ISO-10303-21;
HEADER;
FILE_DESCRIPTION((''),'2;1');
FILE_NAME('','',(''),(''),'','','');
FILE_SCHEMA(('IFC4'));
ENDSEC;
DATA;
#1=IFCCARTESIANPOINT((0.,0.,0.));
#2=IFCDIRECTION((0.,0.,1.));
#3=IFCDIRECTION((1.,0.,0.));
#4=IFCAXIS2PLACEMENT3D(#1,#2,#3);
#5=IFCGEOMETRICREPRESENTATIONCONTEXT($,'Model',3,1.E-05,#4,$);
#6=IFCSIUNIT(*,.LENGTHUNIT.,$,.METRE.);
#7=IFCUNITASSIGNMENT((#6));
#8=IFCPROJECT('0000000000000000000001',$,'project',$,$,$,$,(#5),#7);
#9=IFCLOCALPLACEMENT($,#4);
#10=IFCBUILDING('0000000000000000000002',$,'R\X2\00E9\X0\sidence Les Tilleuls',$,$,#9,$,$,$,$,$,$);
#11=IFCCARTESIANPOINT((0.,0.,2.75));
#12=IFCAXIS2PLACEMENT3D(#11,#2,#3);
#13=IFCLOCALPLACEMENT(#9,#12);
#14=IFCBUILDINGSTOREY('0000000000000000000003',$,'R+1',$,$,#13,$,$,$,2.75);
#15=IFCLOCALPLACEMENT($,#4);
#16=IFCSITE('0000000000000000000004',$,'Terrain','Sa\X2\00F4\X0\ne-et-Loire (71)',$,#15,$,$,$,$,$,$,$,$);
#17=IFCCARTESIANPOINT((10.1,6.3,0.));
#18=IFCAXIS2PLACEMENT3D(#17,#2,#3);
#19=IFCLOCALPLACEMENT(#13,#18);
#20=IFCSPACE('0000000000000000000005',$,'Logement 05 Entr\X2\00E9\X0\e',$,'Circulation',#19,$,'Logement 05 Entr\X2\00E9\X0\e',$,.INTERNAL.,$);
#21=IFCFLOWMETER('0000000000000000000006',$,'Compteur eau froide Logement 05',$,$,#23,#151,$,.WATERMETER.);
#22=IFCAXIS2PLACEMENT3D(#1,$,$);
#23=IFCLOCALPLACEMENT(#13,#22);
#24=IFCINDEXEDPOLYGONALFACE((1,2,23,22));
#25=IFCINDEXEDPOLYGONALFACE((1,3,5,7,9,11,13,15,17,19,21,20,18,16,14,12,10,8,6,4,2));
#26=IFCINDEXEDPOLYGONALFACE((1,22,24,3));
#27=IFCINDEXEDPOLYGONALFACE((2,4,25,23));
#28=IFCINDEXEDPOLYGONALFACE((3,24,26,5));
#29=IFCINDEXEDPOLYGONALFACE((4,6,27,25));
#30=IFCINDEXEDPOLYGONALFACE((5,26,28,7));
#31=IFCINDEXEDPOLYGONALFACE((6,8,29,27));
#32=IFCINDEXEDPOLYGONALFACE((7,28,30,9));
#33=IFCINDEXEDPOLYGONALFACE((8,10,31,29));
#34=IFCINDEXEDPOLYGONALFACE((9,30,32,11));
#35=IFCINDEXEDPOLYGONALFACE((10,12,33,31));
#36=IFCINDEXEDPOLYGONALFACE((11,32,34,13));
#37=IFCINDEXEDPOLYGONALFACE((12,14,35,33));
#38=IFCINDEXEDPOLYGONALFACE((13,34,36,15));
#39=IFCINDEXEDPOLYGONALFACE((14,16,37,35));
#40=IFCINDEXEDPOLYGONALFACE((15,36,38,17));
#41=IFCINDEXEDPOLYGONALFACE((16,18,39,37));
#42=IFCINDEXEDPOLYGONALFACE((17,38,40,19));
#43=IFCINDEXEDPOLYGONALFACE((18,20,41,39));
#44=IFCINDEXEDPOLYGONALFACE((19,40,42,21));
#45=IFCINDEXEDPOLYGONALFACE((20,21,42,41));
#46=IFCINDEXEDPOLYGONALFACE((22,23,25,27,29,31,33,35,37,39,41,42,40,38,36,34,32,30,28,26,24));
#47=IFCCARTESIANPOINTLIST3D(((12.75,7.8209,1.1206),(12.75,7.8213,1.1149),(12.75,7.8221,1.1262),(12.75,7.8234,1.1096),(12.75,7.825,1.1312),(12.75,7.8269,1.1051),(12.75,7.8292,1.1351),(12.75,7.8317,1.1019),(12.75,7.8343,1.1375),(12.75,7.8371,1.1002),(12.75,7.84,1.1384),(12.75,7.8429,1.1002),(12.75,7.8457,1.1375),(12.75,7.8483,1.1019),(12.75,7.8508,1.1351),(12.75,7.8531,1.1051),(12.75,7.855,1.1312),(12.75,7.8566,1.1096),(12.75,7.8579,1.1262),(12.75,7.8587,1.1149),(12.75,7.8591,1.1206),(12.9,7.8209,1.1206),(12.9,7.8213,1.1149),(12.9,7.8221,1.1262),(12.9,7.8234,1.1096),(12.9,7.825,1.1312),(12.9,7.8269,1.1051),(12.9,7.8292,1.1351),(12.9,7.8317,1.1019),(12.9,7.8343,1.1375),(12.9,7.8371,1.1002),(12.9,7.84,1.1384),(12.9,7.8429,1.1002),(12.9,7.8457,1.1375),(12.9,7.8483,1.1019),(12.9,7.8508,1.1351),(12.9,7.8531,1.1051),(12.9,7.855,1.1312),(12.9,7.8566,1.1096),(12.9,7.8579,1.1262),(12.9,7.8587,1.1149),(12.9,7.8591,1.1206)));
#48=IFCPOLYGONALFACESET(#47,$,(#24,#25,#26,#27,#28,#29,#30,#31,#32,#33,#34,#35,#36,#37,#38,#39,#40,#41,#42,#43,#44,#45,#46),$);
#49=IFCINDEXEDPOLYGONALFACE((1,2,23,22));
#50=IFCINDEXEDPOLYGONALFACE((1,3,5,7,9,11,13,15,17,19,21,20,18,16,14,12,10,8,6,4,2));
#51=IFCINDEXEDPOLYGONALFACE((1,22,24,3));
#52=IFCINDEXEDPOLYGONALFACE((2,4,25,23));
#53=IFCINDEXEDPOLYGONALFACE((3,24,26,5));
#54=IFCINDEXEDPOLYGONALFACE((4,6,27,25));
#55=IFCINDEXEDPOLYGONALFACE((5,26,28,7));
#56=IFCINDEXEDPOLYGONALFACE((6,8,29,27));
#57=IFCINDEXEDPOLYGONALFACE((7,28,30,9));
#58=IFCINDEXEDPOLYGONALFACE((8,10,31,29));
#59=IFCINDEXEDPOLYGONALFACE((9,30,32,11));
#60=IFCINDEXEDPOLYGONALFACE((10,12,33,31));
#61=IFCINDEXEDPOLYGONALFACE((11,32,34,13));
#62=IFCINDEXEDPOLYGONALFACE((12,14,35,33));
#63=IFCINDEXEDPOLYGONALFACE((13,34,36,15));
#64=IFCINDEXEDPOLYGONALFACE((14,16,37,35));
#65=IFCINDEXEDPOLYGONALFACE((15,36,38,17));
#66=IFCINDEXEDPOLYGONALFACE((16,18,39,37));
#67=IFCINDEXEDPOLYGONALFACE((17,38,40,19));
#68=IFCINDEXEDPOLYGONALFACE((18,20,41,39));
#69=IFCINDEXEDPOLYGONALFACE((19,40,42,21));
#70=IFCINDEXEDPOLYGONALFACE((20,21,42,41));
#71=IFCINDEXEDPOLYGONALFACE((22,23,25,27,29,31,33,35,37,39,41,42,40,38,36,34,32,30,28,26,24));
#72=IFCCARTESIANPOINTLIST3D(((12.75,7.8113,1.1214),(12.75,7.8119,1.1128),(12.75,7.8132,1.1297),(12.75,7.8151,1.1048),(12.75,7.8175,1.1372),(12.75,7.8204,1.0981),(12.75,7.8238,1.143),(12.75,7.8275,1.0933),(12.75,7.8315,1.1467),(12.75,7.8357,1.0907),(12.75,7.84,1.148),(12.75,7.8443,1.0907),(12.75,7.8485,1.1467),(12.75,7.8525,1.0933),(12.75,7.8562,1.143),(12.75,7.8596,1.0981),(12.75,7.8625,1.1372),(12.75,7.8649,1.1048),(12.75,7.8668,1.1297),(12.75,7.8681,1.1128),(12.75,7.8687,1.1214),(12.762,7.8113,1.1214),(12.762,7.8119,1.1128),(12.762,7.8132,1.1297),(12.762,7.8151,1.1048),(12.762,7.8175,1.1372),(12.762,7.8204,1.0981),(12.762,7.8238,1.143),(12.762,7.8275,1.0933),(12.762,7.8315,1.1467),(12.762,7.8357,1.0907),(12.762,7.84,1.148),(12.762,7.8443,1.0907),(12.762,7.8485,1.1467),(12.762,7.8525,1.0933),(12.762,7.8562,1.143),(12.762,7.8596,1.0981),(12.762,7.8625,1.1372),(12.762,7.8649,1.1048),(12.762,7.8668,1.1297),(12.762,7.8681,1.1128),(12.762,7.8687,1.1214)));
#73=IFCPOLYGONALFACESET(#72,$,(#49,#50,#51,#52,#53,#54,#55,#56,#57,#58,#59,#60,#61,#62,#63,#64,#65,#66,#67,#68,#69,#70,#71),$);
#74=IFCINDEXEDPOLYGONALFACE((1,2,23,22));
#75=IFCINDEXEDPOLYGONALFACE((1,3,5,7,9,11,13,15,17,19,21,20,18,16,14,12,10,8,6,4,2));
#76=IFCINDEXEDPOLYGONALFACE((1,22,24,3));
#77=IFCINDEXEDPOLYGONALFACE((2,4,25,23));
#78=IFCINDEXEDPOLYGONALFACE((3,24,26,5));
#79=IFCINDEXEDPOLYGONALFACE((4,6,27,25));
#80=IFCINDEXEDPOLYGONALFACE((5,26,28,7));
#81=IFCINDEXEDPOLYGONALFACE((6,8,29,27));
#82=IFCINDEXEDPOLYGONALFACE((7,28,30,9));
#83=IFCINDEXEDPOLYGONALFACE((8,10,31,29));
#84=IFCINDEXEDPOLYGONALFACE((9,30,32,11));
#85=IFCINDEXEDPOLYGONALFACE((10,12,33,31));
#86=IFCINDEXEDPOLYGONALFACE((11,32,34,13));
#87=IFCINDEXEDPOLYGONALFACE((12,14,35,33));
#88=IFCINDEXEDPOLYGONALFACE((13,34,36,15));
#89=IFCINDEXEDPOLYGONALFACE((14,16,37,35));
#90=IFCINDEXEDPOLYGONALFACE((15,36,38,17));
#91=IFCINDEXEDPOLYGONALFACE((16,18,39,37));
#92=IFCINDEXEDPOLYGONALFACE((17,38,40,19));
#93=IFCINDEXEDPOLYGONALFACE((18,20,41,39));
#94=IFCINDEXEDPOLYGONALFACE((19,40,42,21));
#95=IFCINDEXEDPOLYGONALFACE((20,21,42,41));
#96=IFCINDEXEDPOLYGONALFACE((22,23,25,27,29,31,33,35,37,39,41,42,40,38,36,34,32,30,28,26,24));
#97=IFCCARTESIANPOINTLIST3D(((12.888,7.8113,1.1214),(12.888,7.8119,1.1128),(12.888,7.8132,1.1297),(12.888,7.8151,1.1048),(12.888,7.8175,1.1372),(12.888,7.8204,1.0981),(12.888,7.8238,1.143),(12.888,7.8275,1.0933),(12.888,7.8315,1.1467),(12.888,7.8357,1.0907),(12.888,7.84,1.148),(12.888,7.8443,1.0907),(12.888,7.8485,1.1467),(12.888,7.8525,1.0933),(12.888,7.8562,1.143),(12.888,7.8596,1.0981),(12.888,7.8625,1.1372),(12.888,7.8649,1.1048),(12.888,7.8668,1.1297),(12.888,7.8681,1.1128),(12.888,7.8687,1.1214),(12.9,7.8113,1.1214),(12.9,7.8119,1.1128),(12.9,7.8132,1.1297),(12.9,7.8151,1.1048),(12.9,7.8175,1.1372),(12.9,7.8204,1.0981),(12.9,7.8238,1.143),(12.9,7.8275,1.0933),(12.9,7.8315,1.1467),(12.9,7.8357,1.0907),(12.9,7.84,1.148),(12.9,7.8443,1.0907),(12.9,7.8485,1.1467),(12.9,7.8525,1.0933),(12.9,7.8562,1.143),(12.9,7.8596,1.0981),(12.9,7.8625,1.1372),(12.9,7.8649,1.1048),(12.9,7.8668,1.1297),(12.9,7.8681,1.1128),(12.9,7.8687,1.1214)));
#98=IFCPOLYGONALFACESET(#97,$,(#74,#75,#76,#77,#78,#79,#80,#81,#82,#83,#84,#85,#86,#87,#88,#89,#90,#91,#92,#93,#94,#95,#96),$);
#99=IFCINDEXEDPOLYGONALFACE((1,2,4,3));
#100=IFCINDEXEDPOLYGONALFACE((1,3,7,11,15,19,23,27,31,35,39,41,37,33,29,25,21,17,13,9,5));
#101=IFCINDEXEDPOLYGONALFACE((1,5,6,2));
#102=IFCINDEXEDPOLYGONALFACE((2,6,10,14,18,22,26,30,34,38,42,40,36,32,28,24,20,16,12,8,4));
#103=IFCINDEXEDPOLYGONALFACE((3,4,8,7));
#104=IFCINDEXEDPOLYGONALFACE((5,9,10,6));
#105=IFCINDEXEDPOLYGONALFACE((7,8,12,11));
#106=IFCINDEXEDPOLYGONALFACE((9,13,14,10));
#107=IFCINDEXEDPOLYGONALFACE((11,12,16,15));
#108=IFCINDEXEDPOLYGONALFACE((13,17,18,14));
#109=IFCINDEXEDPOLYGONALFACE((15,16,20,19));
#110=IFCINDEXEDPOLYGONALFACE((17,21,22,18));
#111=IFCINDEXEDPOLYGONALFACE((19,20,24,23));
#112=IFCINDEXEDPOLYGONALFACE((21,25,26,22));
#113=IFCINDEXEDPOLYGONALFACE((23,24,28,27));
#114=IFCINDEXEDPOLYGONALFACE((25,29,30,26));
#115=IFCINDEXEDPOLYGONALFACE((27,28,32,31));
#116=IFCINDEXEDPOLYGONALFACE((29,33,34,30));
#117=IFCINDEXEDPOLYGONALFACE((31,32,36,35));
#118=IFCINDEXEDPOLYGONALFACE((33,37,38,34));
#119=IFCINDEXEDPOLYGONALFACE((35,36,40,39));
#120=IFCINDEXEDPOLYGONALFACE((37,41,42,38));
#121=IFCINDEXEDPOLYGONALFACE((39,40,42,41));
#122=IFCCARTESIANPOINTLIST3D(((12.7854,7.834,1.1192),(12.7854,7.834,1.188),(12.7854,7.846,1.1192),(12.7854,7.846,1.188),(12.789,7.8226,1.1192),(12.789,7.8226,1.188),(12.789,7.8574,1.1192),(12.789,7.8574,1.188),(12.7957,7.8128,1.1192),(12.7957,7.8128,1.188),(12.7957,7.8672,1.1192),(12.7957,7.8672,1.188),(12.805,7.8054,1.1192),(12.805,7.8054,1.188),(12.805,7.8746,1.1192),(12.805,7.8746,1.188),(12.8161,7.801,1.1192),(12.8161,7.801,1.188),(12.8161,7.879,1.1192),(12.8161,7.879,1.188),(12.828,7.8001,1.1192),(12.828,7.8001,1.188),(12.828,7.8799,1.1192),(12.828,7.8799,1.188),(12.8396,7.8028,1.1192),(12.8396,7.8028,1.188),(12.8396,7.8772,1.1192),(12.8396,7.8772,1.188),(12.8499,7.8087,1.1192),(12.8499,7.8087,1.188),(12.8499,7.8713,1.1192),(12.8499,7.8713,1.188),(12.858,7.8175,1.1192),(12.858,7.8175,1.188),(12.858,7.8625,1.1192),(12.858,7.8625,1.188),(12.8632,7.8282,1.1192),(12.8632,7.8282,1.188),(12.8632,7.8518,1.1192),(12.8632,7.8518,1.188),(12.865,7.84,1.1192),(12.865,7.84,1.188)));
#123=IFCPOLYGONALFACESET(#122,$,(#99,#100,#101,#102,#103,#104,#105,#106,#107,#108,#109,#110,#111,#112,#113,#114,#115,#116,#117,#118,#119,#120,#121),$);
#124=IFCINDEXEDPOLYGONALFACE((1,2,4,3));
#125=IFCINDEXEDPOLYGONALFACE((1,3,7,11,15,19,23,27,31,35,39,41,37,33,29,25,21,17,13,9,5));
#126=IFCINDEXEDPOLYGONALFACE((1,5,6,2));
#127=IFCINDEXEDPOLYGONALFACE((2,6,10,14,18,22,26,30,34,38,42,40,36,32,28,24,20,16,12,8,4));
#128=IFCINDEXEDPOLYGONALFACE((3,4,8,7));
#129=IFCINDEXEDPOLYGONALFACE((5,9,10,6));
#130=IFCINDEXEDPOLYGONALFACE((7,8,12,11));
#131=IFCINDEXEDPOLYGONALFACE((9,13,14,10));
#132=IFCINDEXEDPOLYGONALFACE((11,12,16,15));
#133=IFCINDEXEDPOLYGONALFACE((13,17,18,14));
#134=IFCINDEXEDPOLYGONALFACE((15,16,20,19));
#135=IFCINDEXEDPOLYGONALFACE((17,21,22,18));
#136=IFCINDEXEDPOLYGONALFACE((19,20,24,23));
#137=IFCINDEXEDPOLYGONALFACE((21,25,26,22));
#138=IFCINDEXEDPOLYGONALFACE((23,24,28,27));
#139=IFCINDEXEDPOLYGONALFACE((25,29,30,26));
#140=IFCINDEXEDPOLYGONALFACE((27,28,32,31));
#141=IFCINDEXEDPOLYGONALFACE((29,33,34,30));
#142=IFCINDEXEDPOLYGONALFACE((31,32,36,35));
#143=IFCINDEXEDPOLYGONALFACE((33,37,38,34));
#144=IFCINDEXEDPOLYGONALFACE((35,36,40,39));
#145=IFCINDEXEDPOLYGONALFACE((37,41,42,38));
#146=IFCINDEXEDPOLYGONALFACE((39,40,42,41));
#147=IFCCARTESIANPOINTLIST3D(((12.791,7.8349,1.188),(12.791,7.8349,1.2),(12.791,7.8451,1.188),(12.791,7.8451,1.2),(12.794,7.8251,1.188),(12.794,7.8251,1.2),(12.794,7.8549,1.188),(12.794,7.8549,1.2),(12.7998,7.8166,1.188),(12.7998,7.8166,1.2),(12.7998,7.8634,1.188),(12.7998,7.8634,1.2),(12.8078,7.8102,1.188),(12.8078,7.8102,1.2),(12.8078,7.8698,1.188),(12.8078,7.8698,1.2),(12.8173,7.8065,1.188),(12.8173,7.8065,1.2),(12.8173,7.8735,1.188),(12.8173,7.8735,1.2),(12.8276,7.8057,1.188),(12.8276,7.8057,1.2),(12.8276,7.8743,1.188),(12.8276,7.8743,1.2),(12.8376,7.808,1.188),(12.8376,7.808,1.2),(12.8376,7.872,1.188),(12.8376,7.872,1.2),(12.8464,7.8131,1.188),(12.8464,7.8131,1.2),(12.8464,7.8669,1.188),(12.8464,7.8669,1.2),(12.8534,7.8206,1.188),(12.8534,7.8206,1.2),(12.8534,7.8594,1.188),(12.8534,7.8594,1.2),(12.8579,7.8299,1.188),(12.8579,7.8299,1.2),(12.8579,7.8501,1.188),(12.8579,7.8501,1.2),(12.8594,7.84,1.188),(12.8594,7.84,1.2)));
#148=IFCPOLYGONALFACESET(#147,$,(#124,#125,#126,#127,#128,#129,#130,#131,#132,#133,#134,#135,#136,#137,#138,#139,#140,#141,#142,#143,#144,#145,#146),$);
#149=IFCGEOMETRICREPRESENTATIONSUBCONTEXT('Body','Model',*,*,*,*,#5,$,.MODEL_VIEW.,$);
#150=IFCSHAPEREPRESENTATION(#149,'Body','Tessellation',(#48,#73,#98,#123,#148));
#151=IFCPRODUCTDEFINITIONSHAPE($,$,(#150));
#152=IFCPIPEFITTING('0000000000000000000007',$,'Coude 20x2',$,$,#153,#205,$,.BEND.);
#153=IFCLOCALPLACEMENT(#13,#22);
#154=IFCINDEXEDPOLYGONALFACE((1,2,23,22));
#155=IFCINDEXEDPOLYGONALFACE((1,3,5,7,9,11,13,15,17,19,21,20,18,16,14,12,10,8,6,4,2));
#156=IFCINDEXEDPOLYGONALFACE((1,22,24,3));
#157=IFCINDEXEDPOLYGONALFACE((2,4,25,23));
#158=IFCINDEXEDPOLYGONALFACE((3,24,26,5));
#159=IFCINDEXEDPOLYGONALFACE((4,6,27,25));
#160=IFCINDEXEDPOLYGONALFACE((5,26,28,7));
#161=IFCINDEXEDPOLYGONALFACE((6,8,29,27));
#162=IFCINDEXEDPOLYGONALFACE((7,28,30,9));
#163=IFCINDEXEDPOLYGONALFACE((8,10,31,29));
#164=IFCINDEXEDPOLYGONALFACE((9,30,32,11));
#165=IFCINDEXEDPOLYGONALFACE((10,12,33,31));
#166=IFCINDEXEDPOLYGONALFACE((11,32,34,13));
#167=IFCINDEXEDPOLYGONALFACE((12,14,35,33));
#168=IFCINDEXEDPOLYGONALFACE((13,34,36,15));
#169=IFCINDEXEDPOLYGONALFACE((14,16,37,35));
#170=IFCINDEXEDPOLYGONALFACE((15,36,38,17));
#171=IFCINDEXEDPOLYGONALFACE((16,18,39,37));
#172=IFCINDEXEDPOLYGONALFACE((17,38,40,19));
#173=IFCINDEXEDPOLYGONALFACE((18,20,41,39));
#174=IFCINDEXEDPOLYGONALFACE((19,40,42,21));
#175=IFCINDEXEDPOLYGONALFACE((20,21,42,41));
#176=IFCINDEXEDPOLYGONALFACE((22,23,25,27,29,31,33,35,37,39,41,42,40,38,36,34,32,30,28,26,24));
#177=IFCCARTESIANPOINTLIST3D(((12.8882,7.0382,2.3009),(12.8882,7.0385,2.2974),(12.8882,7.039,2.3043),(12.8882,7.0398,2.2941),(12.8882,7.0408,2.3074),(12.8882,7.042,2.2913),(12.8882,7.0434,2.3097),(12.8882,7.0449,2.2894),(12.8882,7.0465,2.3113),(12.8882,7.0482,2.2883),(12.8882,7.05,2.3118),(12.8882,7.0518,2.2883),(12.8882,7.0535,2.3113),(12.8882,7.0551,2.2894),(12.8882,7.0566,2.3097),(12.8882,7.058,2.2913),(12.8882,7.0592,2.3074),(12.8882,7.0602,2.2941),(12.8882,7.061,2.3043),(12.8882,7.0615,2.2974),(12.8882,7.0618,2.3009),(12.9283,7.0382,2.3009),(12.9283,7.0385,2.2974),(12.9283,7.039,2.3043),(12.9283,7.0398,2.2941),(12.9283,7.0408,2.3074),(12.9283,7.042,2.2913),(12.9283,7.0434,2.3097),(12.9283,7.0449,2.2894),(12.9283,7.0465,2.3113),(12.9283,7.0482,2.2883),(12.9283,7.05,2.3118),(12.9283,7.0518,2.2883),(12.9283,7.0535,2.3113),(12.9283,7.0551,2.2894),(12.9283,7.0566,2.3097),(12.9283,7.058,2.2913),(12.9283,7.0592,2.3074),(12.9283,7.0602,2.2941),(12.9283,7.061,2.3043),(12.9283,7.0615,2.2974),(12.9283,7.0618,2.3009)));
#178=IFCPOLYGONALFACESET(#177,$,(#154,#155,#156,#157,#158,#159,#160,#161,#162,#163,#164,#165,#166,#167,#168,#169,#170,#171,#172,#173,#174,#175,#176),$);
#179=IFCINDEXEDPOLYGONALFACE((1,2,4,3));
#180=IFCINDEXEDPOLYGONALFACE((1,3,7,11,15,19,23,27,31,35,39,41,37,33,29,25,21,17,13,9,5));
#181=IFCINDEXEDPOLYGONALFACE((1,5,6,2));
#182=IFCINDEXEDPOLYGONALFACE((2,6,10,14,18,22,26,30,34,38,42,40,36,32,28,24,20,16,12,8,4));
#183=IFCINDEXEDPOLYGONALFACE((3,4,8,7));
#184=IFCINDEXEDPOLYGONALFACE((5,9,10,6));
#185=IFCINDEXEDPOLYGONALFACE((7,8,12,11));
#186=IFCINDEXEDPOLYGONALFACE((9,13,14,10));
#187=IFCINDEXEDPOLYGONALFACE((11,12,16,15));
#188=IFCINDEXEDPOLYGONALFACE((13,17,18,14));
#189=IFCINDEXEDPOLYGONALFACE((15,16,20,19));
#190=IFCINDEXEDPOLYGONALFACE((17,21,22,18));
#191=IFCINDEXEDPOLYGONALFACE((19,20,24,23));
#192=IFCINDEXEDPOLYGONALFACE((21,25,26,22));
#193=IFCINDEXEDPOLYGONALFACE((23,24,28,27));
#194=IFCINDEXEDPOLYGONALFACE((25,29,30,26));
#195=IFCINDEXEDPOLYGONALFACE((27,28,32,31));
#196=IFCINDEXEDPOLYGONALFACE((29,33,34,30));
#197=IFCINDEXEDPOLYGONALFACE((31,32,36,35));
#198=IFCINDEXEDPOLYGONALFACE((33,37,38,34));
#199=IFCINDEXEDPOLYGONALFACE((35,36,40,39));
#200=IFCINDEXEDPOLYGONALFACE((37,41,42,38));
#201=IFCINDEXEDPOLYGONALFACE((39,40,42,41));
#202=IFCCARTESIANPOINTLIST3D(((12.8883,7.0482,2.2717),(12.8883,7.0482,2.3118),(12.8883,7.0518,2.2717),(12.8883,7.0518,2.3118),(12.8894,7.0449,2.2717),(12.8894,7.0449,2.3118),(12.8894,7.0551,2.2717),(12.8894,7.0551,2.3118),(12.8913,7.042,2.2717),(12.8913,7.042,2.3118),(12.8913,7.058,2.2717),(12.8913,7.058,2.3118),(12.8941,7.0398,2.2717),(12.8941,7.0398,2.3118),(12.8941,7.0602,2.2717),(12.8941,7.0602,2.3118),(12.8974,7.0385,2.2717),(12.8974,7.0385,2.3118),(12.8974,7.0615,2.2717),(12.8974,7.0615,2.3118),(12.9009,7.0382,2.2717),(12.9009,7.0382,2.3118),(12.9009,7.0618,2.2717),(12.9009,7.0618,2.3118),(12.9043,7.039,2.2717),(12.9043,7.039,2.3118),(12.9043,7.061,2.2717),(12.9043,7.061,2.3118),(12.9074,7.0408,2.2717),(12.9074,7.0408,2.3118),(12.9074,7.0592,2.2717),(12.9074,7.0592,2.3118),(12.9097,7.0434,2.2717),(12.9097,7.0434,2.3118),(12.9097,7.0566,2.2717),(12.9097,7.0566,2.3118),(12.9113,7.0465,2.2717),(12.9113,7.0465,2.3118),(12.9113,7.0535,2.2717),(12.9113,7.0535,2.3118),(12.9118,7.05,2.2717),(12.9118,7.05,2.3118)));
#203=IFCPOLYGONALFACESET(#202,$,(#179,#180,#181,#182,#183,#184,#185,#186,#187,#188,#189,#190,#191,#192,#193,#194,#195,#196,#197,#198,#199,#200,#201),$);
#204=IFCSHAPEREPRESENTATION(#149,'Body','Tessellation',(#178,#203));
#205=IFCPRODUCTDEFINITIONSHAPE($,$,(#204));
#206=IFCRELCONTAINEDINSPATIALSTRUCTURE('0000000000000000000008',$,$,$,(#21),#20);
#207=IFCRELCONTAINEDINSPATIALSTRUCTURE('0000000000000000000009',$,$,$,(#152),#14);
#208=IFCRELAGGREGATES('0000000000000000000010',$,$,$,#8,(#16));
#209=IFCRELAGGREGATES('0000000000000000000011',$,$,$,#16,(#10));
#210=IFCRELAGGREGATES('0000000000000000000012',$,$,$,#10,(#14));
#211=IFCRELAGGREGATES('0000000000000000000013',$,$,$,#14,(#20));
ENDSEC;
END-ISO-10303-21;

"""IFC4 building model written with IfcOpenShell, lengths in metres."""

from ifc_helpers import new_model, si_unit, frame, origin_with_axes, place, context, subcontext, project, spatial, circle, extrude, element, save


model = new_model("IFC4")

# Units and contexts
model_context = context("Model", 3, precision=1e-05, world=origin_with_axes())
body_context = subcontext(model_context, "Body", "Model", "MODEL_VIEW")
ifc_project = project(units=[si_unit("LENGTHUNIT", "METRE")], contexts=[model_context])

# Site, building, storey
site_placement = place(None, origin_with_axes())
site = spatial("IfcSite", under=ifc_project, at=site_placement, Name="Terrain", Description="Saône-et-Loire (71)")
building_placement = place(None, origin_with_axes())
building = spatial("IfcBuilding", under=site, at=building_placement, Name="Résidence Les Tilleuls")
storey_placement = place(building_placement, frame((0.0, 0.0, 2.75), z_axis=(0.0, 0.0, 1.0), x_axis=(1.0, 0.0, 0.0)))
storey = spatial("IfcBuildingStorey", under=building, at=storey_placement, Name="R+1", Elevation=2.75)

# Shared definitions
space_1_placement = place(storey_placement, frame((10.1, 6.3, 0.0), z_axis=(0.0, 0.0, 1.0), x_axis=(1.0, 0.0, 0.0)))
space_1 = spatial("IfcSpace", under=storey, at=space_1_placement, Name="Logement 05 Entrée", ObjectType="Circulation", LongName="Logement 05 Entrée", PredefinedType="INTERNAL")

# Flow meter
for number, where, z_axis, x_axis, name in (
    (1, (2.65, 1.5, 1.1), (0.0, 0.0, 1.0), (1.0, 0.0, 0.0), "Compteur eau froide Logement 05"),
):
    element("IfcFlowMeter", number, at=place(space_1_placement, frame(where, z_axis=z_axis, x_axis=x_axis)), inside=space_1, Name=name, PredefinedType="WATERMETER", context=body_context, shape_type="SweptSolid", body=[
        extrude(circle(Radius=0.0192), frame((0.0, 0.04, 0.0192), z_axis=(1.0, 0.0, 0.0), x_axis=(0.0, 0.0, 1.0)), (0.0, 0.0, 1.0), 0.15),
        extrude(circle(Radius=0.0288), frame((0.0, 0.04, 0.0192), z_axis=(1.0, 0.0, 0.0), x_axis=(0.0, 0.0, 1.0)), (0.0, 0.0, 1.0), 0.012),
        extrude(circle(Radius=0.0288), frame((0.138, 0.04, 0.0192), z_axis=(1.0, 0.0, 0.0), x_axis=(0.0, 0.0, 1.0)), (0.0, 0.0, 1.0), 0.012),
        extrude(circle(Radius=0.04), frame((0.075, 0.04, 0.0192), z_axis=(0.0, 0.0, 1.0), x_axis=(1.0, 0.0, 0.0)), (0.0, 0.0, 1.0), 0.0688),
        extrude(circle(Radius=0.0344), frame((0.075, 0.04, 0.088), z_axis=(0.0, 0.0, 1.0), x_axis=(1.0, 0.0, 0.0)), (0.0, 0.0, 1.0), 0.012),
    ])

# Pipe fitting
pipe_fitting_1_placement = place(storey_placement, frame((12.9, 7.05, 2.3), z_axis=(0.0, 0.0, 1.0), x_axis=(1.0, 0.0, 0.0)))
element("IfcPipeFitting", 2, at=pipe_fitting_1_placement, inside=storey, Name="Coude 20x2", PredefinedType="BEND", context=body_context, shape_type="SweptSolid", body=[
    extrude(circle(Radius=0.0118), frame((-0.0118, 0.0, 0.0), z_axis=(1.0, 0.0, 0.0), x_axis=(0.0, 0.0, 1.0)), (0.0, 0.0, 1.0), 0.0401),
    extrude(circle(Radius=0.0118), frame((0.0, 0.0, 0.0118), z_axis=(0.0, 0.0, -1.0), x_axis=(1.0, 0.0, 0.0)), (0.0, 0.0, 1.0), 0.0401),
])

save(model, "model.ifc")
